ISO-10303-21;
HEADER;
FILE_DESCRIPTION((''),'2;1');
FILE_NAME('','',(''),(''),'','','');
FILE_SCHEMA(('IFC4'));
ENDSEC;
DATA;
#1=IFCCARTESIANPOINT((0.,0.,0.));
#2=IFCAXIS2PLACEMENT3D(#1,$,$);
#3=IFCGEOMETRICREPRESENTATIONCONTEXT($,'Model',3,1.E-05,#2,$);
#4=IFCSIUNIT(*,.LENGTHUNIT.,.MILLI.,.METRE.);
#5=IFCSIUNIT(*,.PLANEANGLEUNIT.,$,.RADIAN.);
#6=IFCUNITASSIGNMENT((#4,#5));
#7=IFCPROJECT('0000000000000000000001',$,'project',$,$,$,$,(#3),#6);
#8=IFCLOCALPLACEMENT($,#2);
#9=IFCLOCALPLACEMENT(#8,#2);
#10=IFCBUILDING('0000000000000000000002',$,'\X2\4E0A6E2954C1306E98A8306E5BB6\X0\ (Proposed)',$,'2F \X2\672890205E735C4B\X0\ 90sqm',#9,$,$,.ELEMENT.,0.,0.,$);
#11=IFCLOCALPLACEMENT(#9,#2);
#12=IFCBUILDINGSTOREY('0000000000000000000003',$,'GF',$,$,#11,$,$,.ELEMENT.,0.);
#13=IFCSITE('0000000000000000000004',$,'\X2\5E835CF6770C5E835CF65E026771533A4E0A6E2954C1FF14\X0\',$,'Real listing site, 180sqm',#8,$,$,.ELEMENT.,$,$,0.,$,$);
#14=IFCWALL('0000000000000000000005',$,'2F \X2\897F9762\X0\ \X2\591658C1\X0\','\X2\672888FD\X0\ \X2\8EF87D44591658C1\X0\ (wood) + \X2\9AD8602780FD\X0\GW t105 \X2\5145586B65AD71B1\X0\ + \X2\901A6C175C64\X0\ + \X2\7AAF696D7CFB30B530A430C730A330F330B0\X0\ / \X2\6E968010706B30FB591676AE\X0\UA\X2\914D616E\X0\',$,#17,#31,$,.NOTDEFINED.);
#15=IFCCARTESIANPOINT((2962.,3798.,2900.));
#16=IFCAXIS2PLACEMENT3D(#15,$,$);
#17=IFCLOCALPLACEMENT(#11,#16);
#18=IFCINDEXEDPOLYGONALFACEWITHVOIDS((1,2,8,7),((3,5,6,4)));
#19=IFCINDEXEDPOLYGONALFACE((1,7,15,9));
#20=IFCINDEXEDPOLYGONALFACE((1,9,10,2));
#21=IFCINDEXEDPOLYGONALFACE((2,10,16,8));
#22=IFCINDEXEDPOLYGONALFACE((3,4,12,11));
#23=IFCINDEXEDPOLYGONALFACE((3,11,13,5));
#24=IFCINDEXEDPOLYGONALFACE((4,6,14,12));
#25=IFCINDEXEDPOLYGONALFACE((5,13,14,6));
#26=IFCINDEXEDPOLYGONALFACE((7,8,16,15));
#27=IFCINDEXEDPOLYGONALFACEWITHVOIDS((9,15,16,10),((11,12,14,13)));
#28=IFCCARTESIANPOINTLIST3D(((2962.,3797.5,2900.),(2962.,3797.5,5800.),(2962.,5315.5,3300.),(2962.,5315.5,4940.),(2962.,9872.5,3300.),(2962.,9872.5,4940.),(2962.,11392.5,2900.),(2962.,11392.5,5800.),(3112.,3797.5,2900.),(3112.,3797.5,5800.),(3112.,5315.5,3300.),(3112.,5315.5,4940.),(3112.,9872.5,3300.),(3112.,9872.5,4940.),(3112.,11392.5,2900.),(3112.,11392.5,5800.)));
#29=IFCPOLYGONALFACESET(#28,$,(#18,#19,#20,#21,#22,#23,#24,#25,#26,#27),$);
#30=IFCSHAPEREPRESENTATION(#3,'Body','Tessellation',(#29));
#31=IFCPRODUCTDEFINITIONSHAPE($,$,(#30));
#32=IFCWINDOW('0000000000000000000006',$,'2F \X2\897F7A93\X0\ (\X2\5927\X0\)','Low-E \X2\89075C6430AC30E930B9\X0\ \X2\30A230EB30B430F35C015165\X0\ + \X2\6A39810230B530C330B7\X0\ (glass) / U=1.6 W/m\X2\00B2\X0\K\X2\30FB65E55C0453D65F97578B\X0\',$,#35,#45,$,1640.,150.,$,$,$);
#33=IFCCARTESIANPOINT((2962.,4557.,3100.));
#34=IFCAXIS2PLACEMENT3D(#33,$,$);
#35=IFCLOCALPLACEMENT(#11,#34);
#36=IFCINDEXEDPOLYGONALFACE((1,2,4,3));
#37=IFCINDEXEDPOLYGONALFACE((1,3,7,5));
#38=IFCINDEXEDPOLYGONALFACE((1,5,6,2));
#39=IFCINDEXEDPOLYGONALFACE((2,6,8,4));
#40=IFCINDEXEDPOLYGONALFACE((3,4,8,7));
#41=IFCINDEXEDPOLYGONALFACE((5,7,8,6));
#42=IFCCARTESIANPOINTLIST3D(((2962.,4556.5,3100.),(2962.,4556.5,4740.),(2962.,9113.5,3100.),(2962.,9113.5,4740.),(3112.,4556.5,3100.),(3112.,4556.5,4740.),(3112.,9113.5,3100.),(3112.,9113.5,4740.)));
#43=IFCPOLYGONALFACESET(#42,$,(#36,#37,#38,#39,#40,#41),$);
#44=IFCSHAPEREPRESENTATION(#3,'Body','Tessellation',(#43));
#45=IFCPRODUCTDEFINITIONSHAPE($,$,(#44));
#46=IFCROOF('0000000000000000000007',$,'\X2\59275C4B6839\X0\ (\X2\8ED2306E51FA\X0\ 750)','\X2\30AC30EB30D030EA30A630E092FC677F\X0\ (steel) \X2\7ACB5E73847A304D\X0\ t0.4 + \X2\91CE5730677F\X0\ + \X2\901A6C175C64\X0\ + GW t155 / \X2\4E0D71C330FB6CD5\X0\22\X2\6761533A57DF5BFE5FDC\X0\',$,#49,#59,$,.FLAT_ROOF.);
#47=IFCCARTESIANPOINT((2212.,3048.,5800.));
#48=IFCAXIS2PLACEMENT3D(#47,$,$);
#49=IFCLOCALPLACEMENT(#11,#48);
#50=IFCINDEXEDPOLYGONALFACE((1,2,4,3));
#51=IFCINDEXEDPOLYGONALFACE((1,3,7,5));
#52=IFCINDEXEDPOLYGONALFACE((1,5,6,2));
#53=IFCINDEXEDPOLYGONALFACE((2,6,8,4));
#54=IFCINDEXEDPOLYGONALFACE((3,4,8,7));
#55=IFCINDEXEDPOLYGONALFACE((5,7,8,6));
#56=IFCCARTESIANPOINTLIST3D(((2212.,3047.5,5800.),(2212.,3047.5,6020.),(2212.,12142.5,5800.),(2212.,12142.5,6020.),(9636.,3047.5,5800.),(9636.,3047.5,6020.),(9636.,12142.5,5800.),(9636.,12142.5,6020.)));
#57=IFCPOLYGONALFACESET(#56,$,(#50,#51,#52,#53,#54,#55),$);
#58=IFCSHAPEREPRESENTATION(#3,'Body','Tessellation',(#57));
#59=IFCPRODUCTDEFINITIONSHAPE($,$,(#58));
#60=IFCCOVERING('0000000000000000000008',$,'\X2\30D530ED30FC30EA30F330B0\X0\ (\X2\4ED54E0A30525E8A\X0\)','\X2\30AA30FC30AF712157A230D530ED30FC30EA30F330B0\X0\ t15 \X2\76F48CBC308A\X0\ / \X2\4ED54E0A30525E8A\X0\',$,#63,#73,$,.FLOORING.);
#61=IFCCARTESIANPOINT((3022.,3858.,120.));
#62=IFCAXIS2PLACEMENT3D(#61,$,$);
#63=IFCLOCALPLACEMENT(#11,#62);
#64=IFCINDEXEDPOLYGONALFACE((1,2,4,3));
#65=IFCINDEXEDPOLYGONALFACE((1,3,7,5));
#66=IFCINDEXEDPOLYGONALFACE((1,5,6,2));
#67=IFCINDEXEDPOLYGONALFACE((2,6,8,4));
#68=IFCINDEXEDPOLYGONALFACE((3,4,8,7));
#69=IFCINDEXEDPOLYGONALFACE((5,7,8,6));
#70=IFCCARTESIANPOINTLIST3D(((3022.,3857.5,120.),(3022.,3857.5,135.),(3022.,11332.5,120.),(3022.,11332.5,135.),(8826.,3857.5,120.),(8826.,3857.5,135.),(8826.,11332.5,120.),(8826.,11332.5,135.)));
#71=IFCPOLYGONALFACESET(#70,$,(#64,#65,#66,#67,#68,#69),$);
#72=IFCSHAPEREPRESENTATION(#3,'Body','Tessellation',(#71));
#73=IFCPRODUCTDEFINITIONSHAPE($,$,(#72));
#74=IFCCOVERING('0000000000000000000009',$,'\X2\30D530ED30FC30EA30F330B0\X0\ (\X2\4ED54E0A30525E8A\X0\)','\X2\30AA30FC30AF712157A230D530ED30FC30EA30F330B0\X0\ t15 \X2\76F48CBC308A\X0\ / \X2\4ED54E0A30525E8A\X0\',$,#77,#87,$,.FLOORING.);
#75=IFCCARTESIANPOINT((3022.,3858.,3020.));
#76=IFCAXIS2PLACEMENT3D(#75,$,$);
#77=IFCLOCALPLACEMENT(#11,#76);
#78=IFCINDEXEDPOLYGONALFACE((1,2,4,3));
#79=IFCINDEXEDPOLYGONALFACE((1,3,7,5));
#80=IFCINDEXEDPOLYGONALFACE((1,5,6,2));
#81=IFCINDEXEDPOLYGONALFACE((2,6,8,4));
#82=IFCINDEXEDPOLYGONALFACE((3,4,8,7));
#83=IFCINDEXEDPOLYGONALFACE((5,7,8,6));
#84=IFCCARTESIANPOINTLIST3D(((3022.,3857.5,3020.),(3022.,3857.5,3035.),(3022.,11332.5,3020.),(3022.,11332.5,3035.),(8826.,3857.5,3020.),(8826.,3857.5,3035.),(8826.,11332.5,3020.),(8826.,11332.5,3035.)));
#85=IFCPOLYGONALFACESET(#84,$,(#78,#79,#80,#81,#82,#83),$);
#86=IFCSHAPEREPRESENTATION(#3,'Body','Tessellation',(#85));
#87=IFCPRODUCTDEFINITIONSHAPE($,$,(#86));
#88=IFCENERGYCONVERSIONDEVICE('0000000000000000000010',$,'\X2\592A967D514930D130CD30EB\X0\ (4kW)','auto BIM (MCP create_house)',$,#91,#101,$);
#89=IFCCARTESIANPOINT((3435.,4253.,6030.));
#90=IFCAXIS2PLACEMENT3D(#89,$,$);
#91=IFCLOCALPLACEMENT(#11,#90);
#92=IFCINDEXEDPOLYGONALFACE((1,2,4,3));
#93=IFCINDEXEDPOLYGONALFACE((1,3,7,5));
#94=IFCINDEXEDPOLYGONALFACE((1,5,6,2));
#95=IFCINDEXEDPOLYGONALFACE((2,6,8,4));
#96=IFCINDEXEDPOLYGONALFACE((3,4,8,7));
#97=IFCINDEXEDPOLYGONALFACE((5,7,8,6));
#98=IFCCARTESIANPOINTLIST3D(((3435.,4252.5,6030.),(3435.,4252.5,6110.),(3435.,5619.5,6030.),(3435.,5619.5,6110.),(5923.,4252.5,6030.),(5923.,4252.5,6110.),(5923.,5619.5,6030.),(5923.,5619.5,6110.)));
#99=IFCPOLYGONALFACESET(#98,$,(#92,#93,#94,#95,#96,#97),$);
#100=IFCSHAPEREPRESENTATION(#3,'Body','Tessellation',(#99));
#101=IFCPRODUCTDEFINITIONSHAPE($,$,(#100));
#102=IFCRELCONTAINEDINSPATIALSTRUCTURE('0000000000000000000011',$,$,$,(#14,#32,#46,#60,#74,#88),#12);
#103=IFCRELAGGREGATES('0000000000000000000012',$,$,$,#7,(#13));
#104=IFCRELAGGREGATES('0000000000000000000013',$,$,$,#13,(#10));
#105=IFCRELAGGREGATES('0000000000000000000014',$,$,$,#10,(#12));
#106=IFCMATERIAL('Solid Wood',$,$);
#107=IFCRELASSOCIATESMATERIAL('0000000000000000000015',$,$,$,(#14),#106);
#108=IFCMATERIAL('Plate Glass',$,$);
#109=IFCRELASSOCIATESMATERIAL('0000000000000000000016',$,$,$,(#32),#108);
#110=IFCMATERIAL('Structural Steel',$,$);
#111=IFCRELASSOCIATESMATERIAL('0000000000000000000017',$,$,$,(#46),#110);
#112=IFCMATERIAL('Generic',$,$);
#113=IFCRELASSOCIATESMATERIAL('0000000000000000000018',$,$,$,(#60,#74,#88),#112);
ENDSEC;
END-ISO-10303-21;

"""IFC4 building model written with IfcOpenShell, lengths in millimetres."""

from ifc_helpers import new_model, si_unit, frame, frame_2d, origin, place, context, project, spatial, rectangle, extrude, material, element, fill, save


model = new_model("IFC4")

# Units and contexts
model_context = context("Model", 3, precision=1e-05, world=origin())
ifc_project = project(units=[si_unit("LENGTHUNIT", "METRE", prefix="MILLI"), si_unit("PLANEANGLEUNIT", "RADIAN")], contexts=[model_context])

# Site, building, storey
site_placement = place(None, origin())
site = spatial("IfcSite", under=ifc_project, at=site_placement, Name="広島県広島市東区上温品４", ObjectType="Real listing site, 180sqm", CompositionType="ELEMENT", RefElevation=0.0)
building_placement = place(site_placement, origin())
building = spatial("IfcBuilding", under=site, at=building_placement, Name="上温品の風の家 (Proposed)", ObjectType="2F 木造平屋 90sqm", CompositionType="ELEMENT", ElevationOfRefHeight=0.0, ElevationOfTerrain=0.0)
storey_placement = place(building_placement, origin())
storey = spatial("IfcBuildingStorey", under=building, at=storey_placement, Name="GF", CompositionType="ELEMENT", Elevation=0.0)

# Shared definitions
ifc_material_1 = material(Name="Solid Wood")

# Shared definitions
ifc_material_2 = material(Name="Plate Glass")

# Wall, opening, window
wall_1_placement = place(storey_placement, frame((2962.0, 3798.0, 2900.0)))
wall_1 = element("IfcWall", 1, at=wall_1_placement, inside=storey, material=ifc_material_1, Name="2F 西面 外壁", Description="木製 軸組外壁 (wood) + 高性能GW t105 充填断熱 + 通気層 + 窯業系サイディング / 準耐火・外皮UA配慮", PredefinedType="NOTDEFINED", context=model_context, shape_type="SweptSolid", body=[
    extrude(rectangle(XDim=150.0, YDim=7595.0, at=frame_2d((75.0, 3797.0))), frame((2962.0, 3798.0, 2900.0)), (0.0, 0.0, 1.0), 2900.0),
])
opening_1_placement = place(storey_placement, frame((2962.0, 4557.0, 3100.0)))
opening_1 = element("IfcOpeningElement", 2, at=opening_1_placement, cuts=wall_1, PredefinedType="NOTDEFINED", context=model_context, shape_type="SweptSolid", body=[
    extrude(rectangle(XDim=150.0, YDim=4557.0, at=frame_2d((75.0, 2278.0))), frame((2962.0, 4557.0, 3100.0)), (0.0, 0.0, 1.0), 1640.0),
])
window_1_placement = place(storey_placement, frame((2962.0, 4557.0, 3100.0)))
window_1 = element("IfcWindow", 3, at=window_1_placement, inside=storey, material=ifc_material_2, Name="2F 西窓 (大)", Description="Low-E 複層ガラス アルゴン封入 + 樹脂サッシ (glass) / U=1.6 W/m²K・日射取得型", OverallHeight=1640.0, OverallWidth=150.0, context=model_context, shape_type="SweptSolid", body=[
    extrude(rectangle(XDim=150.0, YDim=4557.0, at=frame_2d((75.0, 2278.0))), frame((2962.0, 4557.0, 3100.0)), (0.0, 0.0, 1.0), 1640.0),
])
fill(opening_1, window_1)

# Roof
ifc_material_3 = material(Name="Structural Steel")
roof_placement = place(storey_placement, frame((2212.0, 3048.0, 5800.0)))
element("IfcRoof", 4, at=roof_placement, inside=storey, material=ifc_material_3, Name="大屋根 (軒の出 750)", Description="ガルバリウム鋼板 (steel) 立平葺き t0.4 + 野地板 + 通気層 + GW t155 / 不燃・法22条区域対応", PredefinedType="FLAT_ROOF", context=model_context, shape_type="SweptSolid", body=[
    extrude(rectangle(XDim=7424.0, YDim=9095.0, at=frame_2d((3712.0, 4547.0))), frame((2212.0, 3048.0, 5800.0)), (0.0, 0.0, 1.0), 220.0),
])

# Coverings
ifc_material_4 = material(Name="Generic")
covering_1_placement = place(storey_placement, frame((3022.0, 3858.0, 120.0)))
element("IfcCovering", 5, at=covering_1_placement, inside=storey, material=ifc_material_4, Name="フローリング (仕上げ床)", Description="オーク無垢フローリング t15 直貼り / 仕上げ床", PredefinedType="FLOORING", context=model_context, shape_type="SweptSolid", body=[
    extrude(rectangle(XDim=5804.0, YDim=7475.0, at=frame_2d((2902.0, 3737.0))), frame((3022.0, 3858.0, 120.0)), (0.0, 0.0, 1.0), 15.0),
])
covering_2_placement = place(storey_placement, frame((3022.0, 3858.0, 3020.0)))
element("IfcCovering", 6, at=covering_2_placement, inside=storey, material=ifc_material_4, Name="フローリング (仕上げ床)", Description="オーク無垢フローリング t15 直貼り / 仕上げ床", PredefinedType="FLOORING", context=model_context, shape_type="SweptSolid", body=[
    extrude(rectangle(XDim=5804.0, YDim=7475.0, at=frame_2d((2902.0, 3737.0))), frame((3022.0, 3858.0, 3020.0)), (0.0, 0.0, 1.0), 15.0),
])

# Energy conversion device
energy_conversion_device_placement = place(storey_placement, frame((3435.0, 4253.0, 6030.0)))
element("IfcEnergyConversionDevice", 7, at=energy_conversion_device_placement, inside=storey, material=ifc_material_4, Name="太陽光パネル (4kW)", Description="auto BIM (MCP create_house)", context=model_context, shape_type="SweptSolid", body=[
    extrude(rectangle(XDim=2488.0, YDim=1367.0, at=frame_2d((1244.0, 683.0))), frame((3435.0, 4253.0, 6030.0)), (0.0, 0.0, 1.0), 80.0),
])

save(model, "model.ifc")
